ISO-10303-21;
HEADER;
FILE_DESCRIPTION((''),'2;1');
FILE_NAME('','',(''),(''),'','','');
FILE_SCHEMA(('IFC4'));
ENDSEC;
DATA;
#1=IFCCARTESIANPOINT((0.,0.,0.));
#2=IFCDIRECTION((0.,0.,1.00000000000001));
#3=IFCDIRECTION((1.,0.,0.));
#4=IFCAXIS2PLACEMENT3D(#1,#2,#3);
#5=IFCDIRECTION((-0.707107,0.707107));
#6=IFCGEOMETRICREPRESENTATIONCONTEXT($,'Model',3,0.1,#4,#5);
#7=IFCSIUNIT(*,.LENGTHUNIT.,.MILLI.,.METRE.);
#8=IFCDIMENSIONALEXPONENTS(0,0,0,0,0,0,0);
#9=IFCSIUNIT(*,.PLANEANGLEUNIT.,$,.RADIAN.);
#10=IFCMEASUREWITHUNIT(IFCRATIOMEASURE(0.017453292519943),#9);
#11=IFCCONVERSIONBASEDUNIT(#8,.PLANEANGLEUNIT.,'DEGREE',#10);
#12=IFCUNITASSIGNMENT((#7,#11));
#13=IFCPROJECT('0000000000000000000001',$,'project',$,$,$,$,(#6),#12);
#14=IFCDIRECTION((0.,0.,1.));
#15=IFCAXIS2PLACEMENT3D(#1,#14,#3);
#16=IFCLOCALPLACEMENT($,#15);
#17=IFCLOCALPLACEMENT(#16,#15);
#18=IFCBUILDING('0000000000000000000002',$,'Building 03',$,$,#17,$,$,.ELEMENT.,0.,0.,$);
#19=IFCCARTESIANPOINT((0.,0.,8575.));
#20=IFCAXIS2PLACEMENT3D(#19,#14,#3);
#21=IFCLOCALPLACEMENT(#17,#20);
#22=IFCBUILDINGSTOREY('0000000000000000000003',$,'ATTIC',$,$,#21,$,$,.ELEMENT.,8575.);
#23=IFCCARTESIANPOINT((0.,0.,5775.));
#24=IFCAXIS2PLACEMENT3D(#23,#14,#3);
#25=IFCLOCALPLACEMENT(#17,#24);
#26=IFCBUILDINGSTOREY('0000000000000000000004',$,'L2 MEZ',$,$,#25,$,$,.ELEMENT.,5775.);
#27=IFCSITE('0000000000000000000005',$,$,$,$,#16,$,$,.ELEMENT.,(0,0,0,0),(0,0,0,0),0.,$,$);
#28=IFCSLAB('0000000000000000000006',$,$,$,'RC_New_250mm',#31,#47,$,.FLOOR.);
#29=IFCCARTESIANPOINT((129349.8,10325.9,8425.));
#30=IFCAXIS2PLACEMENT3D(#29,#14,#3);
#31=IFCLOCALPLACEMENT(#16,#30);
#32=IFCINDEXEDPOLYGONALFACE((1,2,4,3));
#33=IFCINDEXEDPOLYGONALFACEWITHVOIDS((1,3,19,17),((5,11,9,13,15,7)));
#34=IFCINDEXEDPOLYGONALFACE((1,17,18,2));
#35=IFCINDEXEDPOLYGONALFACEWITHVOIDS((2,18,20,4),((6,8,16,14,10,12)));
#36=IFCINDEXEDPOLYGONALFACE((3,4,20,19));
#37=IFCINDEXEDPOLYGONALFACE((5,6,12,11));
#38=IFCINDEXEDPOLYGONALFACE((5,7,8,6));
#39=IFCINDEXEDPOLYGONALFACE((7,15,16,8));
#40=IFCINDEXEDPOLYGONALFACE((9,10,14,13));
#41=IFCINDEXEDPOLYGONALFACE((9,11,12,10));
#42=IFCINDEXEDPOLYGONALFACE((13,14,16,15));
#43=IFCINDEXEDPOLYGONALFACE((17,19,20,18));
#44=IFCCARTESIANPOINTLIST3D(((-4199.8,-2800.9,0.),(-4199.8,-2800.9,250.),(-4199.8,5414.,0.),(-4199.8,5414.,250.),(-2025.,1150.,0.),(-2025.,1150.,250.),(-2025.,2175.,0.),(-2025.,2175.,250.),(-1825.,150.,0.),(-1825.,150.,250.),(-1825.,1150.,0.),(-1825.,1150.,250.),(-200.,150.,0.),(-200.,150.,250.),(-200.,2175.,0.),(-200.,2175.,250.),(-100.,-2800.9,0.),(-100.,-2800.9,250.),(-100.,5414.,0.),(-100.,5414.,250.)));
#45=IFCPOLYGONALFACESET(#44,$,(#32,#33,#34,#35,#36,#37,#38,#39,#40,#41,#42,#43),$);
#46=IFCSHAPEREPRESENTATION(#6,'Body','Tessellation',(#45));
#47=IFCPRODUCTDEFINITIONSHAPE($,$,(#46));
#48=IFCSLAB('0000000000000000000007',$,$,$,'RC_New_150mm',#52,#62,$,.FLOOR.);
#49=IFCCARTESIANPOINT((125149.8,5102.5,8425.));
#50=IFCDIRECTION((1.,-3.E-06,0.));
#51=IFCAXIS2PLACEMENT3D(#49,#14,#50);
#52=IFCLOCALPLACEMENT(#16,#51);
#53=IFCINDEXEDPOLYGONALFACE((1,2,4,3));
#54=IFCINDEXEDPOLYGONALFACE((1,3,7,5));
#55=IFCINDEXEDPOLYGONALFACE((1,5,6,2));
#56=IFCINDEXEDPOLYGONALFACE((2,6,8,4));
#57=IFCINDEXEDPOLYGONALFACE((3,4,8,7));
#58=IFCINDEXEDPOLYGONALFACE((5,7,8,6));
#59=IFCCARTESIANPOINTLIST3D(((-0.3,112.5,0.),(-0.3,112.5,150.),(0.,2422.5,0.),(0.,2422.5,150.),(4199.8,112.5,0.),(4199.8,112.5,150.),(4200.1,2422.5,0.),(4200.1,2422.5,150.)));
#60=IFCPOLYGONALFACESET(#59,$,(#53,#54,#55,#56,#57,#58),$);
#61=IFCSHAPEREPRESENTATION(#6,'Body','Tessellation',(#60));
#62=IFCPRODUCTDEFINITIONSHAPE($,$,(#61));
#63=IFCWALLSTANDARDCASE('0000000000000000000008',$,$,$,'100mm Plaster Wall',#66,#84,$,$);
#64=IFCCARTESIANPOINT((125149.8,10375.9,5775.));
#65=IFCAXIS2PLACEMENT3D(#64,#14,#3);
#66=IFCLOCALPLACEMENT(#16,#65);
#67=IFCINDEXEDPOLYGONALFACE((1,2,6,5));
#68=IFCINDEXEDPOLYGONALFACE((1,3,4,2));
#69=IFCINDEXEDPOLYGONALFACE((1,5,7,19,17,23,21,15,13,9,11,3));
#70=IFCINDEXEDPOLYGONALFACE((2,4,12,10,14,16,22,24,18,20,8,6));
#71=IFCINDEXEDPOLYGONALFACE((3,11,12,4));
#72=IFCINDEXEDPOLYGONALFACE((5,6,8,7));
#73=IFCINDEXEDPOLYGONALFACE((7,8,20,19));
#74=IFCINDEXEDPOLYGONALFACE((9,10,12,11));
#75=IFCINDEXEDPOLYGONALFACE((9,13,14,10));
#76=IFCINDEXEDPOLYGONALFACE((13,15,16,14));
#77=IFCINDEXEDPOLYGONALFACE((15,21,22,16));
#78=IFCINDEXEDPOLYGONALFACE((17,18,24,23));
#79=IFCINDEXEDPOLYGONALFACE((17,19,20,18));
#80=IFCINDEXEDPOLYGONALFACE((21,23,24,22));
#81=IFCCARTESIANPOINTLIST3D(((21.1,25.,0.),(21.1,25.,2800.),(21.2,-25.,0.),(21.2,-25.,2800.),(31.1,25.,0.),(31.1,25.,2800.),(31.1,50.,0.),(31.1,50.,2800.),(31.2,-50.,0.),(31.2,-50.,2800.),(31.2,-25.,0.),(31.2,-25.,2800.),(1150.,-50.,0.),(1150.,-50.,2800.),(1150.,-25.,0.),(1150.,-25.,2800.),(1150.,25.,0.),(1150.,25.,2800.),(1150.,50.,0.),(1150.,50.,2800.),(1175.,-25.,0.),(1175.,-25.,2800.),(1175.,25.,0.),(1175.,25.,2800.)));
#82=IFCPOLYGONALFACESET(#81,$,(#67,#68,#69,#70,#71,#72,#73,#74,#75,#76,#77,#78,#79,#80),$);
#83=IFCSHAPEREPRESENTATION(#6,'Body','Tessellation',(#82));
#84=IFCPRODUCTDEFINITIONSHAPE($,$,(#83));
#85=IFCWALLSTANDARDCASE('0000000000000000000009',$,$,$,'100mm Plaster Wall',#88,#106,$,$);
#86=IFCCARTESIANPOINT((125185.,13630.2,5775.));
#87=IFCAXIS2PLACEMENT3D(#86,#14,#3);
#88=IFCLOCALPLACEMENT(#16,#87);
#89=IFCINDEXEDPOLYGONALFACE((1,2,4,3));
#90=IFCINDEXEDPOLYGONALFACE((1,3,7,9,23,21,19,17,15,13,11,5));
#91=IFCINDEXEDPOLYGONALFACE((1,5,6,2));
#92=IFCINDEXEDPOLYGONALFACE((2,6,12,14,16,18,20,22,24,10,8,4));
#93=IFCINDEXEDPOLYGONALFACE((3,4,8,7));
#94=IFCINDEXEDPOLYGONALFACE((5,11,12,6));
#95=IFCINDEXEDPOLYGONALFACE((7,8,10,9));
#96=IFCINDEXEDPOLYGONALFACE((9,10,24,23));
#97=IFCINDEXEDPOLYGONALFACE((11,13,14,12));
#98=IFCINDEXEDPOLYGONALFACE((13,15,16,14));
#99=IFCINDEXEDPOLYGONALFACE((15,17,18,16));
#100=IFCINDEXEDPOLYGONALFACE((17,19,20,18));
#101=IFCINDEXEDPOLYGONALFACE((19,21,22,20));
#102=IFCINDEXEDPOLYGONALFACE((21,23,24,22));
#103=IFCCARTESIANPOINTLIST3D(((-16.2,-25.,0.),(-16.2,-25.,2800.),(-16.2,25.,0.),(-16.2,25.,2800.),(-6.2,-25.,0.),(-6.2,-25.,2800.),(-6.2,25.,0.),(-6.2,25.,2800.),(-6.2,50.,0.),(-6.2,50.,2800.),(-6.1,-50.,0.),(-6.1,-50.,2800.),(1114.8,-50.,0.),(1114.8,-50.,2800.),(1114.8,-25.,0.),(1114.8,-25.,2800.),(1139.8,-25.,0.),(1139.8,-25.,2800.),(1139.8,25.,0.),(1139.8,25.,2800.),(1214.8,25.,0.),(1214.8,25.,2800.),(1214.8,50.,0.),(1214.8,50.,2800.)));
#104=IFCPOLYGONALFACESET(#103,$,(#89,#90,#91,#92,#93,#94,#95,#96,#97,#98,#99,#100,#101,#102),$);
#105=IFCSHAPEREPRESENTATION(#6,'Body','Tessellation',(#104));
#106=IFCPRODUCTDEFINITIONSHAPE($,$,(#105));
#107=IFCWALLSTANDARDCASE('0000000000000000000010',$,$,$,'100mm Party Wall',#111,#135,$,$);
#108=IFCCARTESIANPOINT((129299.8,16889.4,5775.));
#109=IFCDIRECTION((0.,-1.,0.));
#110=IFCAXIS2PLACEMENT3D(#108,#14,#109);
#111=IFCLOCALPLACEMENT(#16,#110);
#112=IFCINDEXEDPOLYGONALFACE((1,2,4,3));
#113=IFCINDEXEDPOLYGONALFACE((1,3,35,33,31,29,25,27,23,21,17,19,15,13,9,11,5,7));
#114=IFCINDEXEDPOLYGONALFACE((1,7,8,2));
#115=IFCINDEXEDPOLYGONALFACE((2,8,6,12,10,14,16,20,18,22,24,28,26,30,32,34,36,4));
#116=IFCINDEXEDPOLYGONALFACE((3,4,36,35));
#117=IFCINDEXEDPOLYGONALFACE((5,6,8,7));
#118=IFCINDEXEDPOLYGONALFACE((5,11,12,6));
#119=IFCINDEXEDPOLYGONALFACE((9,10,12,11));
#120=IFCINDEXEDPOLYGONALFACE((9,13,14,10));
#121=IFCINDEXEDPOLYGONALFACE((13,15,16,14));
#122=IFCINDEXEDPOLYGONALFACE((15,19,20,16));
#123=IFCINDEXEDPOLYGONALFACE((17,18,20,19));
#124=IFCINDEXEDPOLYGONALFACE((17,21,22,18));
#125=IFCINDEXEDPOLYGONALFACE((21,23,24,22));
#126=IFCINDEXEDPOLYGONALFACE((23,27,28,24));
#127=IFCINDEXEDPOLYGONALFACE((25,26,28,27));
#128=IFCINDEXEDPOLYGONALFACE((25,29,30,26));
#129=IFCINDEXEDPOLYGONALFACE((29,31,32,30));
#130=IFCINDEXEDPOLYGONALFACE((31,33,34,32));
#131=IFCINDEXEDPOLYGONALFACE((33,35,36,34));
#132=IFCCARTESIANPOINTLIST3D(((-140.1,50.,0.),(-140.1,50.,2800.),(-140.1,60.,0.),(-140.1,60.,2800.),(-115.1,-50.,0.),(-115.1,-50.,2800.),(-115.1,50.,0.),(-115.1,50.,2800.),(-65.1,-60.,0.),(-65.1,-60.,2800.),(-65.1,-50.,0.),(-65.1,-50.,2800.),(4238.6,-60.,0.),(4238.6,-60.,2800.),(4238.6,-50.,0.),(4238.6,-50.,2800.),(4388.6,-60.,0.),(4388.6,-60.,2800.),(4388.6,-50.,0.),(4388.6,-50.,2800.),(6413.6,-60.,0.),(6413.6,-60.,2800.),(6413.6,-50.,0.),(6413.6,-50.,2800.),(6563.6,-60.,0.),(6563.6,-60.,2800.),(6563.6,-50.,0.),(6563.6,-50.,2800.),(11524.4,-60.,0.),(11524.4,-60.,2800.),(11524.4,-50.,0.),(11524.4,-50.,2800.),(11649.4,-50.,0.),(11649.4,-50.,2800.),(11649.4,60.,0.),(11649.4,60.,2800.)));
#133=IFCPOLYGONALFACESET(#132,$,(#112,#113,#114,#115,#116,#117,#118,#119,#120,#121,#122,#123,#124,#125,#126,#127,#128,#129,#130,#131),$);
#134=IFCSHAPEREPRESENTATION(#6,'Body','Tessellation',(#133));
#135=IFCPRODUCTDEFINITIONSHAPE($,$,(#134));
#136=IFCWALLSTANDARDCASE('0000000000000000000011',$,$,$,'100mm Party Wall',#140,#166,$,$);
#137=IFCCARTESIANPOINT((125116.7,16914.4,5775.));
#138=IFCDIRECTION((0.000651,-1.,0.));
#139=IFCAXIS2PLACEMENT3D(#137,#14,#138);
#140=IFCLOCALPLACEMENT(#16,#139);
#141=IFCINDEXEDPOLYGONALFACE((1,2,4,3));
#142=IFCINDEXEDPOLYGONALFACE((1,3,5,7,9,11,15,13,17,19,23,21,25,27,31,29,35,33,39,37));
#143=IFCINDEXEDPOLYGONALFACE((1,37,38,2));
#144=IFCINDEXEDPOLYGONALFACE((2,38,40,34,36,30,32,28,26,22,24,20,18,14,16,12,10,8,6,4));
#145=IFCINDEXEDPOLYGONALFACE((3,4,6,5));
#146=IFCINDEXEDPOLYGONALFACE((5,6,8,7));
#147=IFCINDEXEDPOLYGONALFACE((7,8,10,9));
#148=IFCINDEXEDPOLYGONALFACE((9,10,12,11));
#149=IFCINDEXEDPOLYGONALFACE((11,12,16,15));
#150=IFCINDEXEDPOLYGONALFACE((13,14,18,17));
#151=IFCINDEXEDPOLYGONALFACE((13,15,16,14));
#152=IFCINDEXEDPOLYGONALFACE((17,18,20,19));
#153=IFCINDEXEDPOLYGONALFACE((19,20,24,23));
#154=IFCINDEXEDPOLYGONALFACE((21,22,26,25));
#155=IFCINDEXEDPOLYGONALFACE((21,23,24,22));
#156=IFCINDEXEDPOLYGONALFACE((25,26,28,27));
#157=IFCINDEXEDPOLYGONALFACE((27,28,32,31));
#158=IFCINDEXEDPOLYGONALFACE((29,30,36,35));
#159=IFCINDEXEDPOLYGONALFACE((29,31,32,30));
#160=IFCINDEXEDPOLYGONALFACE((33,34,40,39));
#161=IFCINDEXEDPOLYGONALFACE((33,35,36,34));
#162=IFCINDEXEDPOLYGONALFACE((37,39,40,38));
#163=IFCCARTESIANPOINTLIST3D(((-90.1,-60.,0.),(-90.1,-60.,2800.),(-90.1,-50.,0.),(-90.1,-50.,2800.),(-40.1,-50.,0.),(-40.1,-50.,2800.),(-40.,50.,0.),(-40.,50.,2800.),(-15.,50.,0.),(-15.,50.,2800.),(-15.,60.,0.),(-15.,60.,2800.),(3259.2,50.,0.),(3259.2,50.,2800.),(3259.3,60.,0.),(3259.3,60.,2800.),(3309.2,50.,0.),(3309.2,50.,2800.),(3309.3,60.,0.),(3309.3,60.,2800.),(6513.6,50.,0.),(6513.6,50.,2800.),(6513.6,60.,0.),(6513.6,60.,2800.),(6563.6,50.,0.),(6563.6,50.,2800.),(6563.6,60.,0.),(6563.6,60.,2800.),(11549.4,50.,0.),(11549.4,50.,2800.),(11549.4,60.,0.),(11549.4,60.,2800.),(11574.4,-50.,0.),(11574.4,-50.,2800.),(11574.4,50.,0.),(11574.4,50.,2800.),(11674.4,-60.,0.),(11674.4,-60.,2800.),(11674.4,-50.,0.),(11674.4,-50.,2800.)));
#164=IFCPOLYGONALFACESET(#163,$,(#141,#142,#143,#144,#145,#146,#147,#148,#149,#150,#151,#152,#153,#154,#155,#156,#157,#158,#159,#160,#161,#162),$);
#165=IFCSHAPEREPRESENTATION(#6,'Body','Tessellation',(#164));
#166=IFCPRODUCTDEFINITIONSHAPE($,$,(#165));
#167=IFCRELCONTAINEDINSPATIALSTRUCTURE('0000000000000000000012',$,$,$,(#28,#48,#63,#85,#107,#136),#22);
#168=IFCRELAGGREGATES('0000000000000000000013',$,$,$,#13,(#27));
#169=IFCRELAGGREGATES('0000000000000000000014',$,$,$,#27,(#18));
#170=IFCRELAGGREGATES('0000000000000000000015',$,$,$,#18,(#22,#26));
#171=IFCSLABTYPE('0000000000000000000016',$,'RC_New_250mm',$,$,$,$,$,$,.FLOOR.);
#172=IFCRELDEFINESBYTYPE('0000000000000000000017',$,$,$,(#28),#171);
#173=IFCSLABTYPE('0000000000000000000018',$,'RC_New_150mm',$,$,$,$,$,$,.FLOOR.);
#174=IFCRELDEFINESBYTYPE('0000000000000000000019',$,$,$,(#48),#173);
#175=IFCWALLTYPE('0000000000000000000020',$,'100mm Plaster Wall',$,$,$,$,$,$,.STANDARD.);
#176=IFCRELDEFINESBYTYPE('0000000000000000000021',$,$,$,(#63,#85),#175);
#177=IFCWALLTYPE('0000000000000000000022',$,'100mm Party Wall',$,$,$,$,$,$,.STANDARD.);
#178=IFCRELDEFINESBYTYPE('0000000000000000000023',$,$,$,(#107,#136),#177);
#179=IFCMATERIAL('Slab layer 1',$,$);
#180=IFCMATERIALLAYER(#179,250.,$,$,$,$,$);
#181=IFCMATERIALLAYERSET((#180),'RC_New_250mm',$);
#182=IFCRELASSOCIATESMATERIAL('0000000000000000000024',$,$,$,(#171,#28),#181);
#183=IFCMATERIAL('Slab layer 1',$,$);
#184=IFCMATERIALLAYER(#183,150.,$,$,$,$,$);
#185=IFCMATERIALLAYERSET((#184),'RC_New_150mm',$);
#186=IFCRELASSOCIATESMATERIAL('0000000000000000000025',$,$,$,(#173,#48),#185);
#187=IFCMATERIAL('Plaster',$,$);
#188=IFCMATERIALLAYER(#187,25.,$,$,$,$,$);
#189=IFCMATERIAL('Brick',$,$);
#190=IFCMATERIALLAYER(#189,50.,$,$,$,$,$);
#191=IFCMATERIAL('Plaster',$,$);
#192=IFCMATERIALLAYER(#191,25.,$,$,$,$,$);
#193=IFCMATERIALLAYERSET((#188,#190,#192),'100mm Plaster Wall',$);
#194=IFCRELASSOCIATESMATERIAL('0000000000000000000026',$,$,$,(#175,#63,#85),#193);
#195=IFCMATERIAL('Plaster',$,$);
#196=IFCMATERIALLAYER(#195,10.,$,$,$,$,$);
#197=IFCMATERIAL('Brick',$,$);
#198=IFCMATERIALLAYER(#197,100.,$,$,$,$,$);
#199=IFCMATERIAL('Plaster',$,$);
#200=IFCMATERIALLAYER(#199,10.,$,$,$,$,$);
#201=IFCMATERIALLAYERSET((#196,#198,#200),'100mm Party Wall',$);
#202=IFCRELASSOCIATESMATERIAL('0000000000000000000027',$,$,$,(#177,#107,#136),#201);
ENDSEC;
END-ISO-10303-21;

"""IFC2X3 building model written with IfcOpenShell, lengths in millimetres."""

from ifc_helpers import new_model, entity, si_unit, converted_unit, direction, frame, origin_with_axes, place, context, project, spatial, polyline, outline, extrude, material, layer, layer_set, layer_usage, type_object, element, save


model = new_model("IFC2X3")

# Units and contexts
model_context = context("Model", 3, precision=0.1, world=frame((0.0, 0.0, 0.0), z_axis=(0.0, 0.0, 1.00000000000001), x_axis=(1.0, 0.0, 0.0)), true_north=direction((-0.707107, 0.707107)))
ifc_project = project(units=[si_unit("LENGTHUNIT", "METRE", prefix="MILLI"), converted_unit("PLANEANGLEUNIT", "DEGREE", entity("IfcRatioMeasure", 0.017453292519943), si_unit("PLANEANGLEUNIT", "RADIAN"), dimensions=[0, 0, 0, 0, 0, 0, 0])], contexts=[model_context])

# Site, building, storey
site_placement = place(None, origin_with_axes())
site = spatial("IfcSite", under=ifc_project, at=site_placement, CompositionType="ELEMENT", RefLatitude=(0, 0, 0, 0), RefLongitude=(0, 0, 0, 0), RefElevation=0.0)
building_placement = place(site_placement, origin_with_axes())
building = spatial("IfcBuilding", under=site, at=building_placement, Name="Building 03", CompositionType="ELEMENT", ElevationOfRefHeight=0.0, ElevationOfTerrain=0.0)
storey_1_placement = place(building_placement, frame((0.0, 0.0, 8575.0), z_axis=(0.0, 0.0, 1.0), x_axis=(1.0, 0.0, 0.0)))
storey_1 = spatial("IfcBuildingStorey", under=building, at=storey_1_placement, Name="ATTIC", CompositionType="ELEMENT", Elevation=8575.0)

# Shared definitions
ifc_material_1 = material(Name="Slab layer 1")
ifc_layer_1 = layer(ifc_material_1, 250.0)
ifc_layer_set_1 = layer_set([ifc_layer_1], Name="RC_New_250mm")
ifc_layer_usage_1 = layer_usage(ifc_layer_set_1, "AXIS3", "POSITIVE", 0.0)
slab_type_1 = type_object("IfcSlabType", Name="RC_New_250mm", PredefinedType="FLOOR", material=ifc_layer_set_1)

# Slab, opening
slab_1_placement = place(site_placement, frame((129349.8, 10325.9, 8425.0), z_axis=(0.0, 0.0, 1.0), x_axis=(1.0, 0.0, 0.0)))
slab_1 = element("IfcSlab", 1, at=slab_1_placement, inside=storey_1, type_object=slab_type_1, material=ifc_layer_usage_1, ObjectType="RC_New_250mm", PredefinedType="FLOOR", context=model_context, shape_type="SweptSolid", body=[
    extrude(outline(polyline([(-100.0, 5414.0), (-4199.8, 5414.0), (-4199.8, -2800.9), (-100.0, -2800.9), (-100.0, 5414.0)])), origin_with_axes(), (0.0, 0.0, 1.0), 250.0),
])
opening_1_placement = place(site_placement, frame((129349.8, 10325.9, 8425.0), z_axis=(0.0, 0.0, 1.0), x_axis=(1.0, 0.0, 0.0)))
element("IfcOpeningElement", 2, at=opening_1_placement, cuts=slab_1, context=model_context, shape_type="SweptSolid", body=[
    extrude(outline(polyline([(-2025.0, 1150.0), (-1825.0, 1150.0), (-1825.0, 150.0), (-200.0, 150.0), (-200.0, 2175.0), (-2025.0, 2175.0), (-2025.0, 1150.0)])), origin_with_axes(), (0.0, 0.0, 1.0), 250.0),
])

# Slab
ifc_material_2 = material(Name="Slab layer 1")
ifc_layer_2 = layer(ifc_material_2, 150.0)
ifc_layer_set_2 = layer_set([ifc_layer_2], Name="RC_New_150mm")
ifc_layer_usage_2 = layer_usage(ifc_layer_set_2, "AXIS3", "POSITIVE", 0.0)
slab_type_2 = type_object("IfcSlabType", Name="RC_New_150mm", PredefinedType="FLOOR", material=ifc_layer_set_2)
slab_2_placement = place(site_placement, frame((125149.8, 5102.5, 8425.0), z_axis=(0.0, 0.0, 1.0), x_axis=(1.0, -0.000003, 0.0)))
element("IfcSlab", 3, at=slab_2_placement, inside=storey_1, type_object=slab_type_2, material=ifc_layer_usage_2, ObjectType="RC_New_150mm", PredefinedType="FLOOR", context=model_context, shape_type="SweptSolid", body=[
    extrude(outline(polyline([(-0.3, 112.5), (4199.8, 112.5), (4200.1, 2422.5), (0.0, 2422.5), (-0.3, 112.5)])), origin_with_axes(), (0.0, 0.0, 1.0), 150.0),
])

# Shared definitions
ifc_material_3 = material(Name="Plaster")
ifc_layer_3 = layer(ifc_material_3, 25.0)
ifc_material_4 = material(Name="Brick")
ifc_layer_4 = layer(ifc_material_4, 50.0)
ifc_material_5 = material(Name="Plaster")
ifc_layer_5 = layer(ifc_material_5, 25.0)
ifc_layer_set_3 = layer_set([ifc_layer_3, ifc_layer_4, ifc_layer_5], Name="100mm Plaster Wall")
ifc_layer_usage_3 = layer_usage(ifc_layer_set_3, "AXIS2", "POSITIVE", -50.0)
wall_type_1 = type_object("IfcWallType", Name="100mm Plaster Wall", PredefinedType="STANDARD", material=ifc_layer_set_3)

# Shared definitions
storey_2_placement = place(building_placement, frame((0.0, 0.0, 5775.0), z_axis=(0.0, 0.0, 1.0), x_axis=(1.0, 0.0, 0.0)))
storey_2 = spatial("IfcBuildingStorey", under=building, at=storey_2_placement, Name="L2 MEZ", CompositionType="ELEMENT", Elevation=5775.0)

# Walls
wall_1_placement = place(site_placement, frame((125149.8, 10375.9, 5775.0), z_axis=(0.0, 0.0, 1.0), x_axis=(1.0, 0.0, 0.0)))
element("IfcWallStandardCase", 4, at=wall_1_placement, inside=storey_1, type_object=wall_type_1, material=ifc_layer_usage_3, ObjectType="100mm Plaster Wall", context=model_context, shape_type="SweptSolid", body=[
    extrude(outline(polyline([(1150.0, 25.0), (1150.0, 50.0), (31.1, 50.0), (31.1, 25.0), (21.1, 25.0), (21.2, -25.0), (31.2, -25.0), (31.2, -50.0), (1150.0, -50.0), (1150.0, -25.0), (1175.0, -25.0), (1175.0, 25.0), (1150.0, 25.0)])), origin_with_axes(), (0.0, 0.0, 1.0), 2800.0),
])
wall_2_placement = place(site_placement, frame((125185.0, 13630.2, 5775.0), z_axis=(0.0, 0.0, 1.0), x_axis=(1.0, 0.0, 0.0)))
element("IfcWallStandardCase", 5, at=wall_2_placement, inside=storey_1, type_object=wall_type_1, material=ifc_layer_usage_3, ObjectType="100mm Plaster Wall", context=model_context, shape_type="SweptSolid", body=[
    extrude(outline(polyline([(1214.8, 50.0), (1214.8, 25.0), (1139.8, 25.0), (1139.8, -25.0), (1114.8, -25.0), (1114.8, -50.0), (-6.1, -50.0), (-6.2, -25.0), (-16.2, -25.0), (-16.2, 25.0), (-6.2, 25.0), (-6.2, 50.0), (1214.8, 50.0)])), origin_with_axes(), (0.0, 0.0, 1.0), 2800.0),
])
ifc_material_6 = material(Name="Plaster")
ifc_layer_6 = layer(ifc_material_6, 10.0)
ifc_material_7 = material(Name="Brick")
ifc_layer_7 = layer(ifc_material_7, 100.0)
ifc_material_8 = material(Name="Plaster")
ifc_layer_8 = layer(ifc_material_8, 10.0)
ifc_layer_set_4 = layer_set([ifc_layer_6, ifc_layer_7, ifc_layer_8], Name="100mm Party Wall")
ifc_layer_usage_4 = layer_usage(ifc_layer_set_4, "AXIS2", "POSITIVE", -60.0)
wall_type_2 = type_object("IfcWallType", Name="100mm Party Wall", PredefinedType="STANDARD", material=ifc_layer_set_4)
wall_3_placement = place(site_placement, frame((129299.8, 16889.4, 5775.0), z_axis=(0.0, 0.0, 1.0), x_axis=(0.0, -1.0, 0.0)))
element("IfcWallStandardCase", 6, at=wall_3_placement, inside=storey_1, type_object=wall_type_2, material=ifc_layer_usage_4, ObjectType="100mm Party Wall", context=model_context, shape_type="SweptSolid", body=[
    extrude(outline(polyline([(11649.4, 60.0), (11649.4, -50.0), (11524.4, -50.0), (11524.4, -60.0), (6563.6, -60.0), (6563.6, -50.0), (6413.6, -50.0), (6413.6, -60.0), (4388.6, -60.0), (4388.6, -50.0), (4238.6, -50.0), (4238.6, -60.0), (-65.1, -60.0), (-65.1, -50.0), (-115.1, -50.0), (-115.1, 50.0), (-140.1, 50.0), (-140.1, 60.0), (11649.4, 60.0)])), origin_with_axes(), (0.0, 0.0, 1.0), 2800.0),
])
wall_4_placement = place(site_placement, frame((125116.7, 16914.4, 5775.0), z_axis=(0.0, 0.0, 1.0), x_axis=(0.000651, -1.0, 0.0)))
element("IfcWallStandardCase", 7, at=wall_4_placement, inside=storey_1, type_object=wall_type_2, material=ifc_layer_usage_4, ObjectType="100mm Party Wall", context=model_context, shape_type="SweptSolid", body=[
    extrude(outline(polyline([(6513.6, 60.0), (6513.6, 50.0), (6563.6, 50.0), (6563.6, 60.0), (11549.4, 60.0), (11549.4, 50.0), (11574.4, 50.0), (11574.4, -50.0), (11674.4, -50.0), (11674.4, -60.0), (-90.1, -60.0), (-90.1, -50.0), (-40.1, -50.0), (-40.0, 50.0), (-15.0, 50.0), (-15.0, 60.0), (3259.3, 60.0), (3259.2, 50.0), (3309.2, 50.0), (3309.3, 60.0), (6513.6, 60.0)])), origin_with_axes(), (0.0, 0.0, 1.0), 2800.0),
])

save(model, "model.ifc")
